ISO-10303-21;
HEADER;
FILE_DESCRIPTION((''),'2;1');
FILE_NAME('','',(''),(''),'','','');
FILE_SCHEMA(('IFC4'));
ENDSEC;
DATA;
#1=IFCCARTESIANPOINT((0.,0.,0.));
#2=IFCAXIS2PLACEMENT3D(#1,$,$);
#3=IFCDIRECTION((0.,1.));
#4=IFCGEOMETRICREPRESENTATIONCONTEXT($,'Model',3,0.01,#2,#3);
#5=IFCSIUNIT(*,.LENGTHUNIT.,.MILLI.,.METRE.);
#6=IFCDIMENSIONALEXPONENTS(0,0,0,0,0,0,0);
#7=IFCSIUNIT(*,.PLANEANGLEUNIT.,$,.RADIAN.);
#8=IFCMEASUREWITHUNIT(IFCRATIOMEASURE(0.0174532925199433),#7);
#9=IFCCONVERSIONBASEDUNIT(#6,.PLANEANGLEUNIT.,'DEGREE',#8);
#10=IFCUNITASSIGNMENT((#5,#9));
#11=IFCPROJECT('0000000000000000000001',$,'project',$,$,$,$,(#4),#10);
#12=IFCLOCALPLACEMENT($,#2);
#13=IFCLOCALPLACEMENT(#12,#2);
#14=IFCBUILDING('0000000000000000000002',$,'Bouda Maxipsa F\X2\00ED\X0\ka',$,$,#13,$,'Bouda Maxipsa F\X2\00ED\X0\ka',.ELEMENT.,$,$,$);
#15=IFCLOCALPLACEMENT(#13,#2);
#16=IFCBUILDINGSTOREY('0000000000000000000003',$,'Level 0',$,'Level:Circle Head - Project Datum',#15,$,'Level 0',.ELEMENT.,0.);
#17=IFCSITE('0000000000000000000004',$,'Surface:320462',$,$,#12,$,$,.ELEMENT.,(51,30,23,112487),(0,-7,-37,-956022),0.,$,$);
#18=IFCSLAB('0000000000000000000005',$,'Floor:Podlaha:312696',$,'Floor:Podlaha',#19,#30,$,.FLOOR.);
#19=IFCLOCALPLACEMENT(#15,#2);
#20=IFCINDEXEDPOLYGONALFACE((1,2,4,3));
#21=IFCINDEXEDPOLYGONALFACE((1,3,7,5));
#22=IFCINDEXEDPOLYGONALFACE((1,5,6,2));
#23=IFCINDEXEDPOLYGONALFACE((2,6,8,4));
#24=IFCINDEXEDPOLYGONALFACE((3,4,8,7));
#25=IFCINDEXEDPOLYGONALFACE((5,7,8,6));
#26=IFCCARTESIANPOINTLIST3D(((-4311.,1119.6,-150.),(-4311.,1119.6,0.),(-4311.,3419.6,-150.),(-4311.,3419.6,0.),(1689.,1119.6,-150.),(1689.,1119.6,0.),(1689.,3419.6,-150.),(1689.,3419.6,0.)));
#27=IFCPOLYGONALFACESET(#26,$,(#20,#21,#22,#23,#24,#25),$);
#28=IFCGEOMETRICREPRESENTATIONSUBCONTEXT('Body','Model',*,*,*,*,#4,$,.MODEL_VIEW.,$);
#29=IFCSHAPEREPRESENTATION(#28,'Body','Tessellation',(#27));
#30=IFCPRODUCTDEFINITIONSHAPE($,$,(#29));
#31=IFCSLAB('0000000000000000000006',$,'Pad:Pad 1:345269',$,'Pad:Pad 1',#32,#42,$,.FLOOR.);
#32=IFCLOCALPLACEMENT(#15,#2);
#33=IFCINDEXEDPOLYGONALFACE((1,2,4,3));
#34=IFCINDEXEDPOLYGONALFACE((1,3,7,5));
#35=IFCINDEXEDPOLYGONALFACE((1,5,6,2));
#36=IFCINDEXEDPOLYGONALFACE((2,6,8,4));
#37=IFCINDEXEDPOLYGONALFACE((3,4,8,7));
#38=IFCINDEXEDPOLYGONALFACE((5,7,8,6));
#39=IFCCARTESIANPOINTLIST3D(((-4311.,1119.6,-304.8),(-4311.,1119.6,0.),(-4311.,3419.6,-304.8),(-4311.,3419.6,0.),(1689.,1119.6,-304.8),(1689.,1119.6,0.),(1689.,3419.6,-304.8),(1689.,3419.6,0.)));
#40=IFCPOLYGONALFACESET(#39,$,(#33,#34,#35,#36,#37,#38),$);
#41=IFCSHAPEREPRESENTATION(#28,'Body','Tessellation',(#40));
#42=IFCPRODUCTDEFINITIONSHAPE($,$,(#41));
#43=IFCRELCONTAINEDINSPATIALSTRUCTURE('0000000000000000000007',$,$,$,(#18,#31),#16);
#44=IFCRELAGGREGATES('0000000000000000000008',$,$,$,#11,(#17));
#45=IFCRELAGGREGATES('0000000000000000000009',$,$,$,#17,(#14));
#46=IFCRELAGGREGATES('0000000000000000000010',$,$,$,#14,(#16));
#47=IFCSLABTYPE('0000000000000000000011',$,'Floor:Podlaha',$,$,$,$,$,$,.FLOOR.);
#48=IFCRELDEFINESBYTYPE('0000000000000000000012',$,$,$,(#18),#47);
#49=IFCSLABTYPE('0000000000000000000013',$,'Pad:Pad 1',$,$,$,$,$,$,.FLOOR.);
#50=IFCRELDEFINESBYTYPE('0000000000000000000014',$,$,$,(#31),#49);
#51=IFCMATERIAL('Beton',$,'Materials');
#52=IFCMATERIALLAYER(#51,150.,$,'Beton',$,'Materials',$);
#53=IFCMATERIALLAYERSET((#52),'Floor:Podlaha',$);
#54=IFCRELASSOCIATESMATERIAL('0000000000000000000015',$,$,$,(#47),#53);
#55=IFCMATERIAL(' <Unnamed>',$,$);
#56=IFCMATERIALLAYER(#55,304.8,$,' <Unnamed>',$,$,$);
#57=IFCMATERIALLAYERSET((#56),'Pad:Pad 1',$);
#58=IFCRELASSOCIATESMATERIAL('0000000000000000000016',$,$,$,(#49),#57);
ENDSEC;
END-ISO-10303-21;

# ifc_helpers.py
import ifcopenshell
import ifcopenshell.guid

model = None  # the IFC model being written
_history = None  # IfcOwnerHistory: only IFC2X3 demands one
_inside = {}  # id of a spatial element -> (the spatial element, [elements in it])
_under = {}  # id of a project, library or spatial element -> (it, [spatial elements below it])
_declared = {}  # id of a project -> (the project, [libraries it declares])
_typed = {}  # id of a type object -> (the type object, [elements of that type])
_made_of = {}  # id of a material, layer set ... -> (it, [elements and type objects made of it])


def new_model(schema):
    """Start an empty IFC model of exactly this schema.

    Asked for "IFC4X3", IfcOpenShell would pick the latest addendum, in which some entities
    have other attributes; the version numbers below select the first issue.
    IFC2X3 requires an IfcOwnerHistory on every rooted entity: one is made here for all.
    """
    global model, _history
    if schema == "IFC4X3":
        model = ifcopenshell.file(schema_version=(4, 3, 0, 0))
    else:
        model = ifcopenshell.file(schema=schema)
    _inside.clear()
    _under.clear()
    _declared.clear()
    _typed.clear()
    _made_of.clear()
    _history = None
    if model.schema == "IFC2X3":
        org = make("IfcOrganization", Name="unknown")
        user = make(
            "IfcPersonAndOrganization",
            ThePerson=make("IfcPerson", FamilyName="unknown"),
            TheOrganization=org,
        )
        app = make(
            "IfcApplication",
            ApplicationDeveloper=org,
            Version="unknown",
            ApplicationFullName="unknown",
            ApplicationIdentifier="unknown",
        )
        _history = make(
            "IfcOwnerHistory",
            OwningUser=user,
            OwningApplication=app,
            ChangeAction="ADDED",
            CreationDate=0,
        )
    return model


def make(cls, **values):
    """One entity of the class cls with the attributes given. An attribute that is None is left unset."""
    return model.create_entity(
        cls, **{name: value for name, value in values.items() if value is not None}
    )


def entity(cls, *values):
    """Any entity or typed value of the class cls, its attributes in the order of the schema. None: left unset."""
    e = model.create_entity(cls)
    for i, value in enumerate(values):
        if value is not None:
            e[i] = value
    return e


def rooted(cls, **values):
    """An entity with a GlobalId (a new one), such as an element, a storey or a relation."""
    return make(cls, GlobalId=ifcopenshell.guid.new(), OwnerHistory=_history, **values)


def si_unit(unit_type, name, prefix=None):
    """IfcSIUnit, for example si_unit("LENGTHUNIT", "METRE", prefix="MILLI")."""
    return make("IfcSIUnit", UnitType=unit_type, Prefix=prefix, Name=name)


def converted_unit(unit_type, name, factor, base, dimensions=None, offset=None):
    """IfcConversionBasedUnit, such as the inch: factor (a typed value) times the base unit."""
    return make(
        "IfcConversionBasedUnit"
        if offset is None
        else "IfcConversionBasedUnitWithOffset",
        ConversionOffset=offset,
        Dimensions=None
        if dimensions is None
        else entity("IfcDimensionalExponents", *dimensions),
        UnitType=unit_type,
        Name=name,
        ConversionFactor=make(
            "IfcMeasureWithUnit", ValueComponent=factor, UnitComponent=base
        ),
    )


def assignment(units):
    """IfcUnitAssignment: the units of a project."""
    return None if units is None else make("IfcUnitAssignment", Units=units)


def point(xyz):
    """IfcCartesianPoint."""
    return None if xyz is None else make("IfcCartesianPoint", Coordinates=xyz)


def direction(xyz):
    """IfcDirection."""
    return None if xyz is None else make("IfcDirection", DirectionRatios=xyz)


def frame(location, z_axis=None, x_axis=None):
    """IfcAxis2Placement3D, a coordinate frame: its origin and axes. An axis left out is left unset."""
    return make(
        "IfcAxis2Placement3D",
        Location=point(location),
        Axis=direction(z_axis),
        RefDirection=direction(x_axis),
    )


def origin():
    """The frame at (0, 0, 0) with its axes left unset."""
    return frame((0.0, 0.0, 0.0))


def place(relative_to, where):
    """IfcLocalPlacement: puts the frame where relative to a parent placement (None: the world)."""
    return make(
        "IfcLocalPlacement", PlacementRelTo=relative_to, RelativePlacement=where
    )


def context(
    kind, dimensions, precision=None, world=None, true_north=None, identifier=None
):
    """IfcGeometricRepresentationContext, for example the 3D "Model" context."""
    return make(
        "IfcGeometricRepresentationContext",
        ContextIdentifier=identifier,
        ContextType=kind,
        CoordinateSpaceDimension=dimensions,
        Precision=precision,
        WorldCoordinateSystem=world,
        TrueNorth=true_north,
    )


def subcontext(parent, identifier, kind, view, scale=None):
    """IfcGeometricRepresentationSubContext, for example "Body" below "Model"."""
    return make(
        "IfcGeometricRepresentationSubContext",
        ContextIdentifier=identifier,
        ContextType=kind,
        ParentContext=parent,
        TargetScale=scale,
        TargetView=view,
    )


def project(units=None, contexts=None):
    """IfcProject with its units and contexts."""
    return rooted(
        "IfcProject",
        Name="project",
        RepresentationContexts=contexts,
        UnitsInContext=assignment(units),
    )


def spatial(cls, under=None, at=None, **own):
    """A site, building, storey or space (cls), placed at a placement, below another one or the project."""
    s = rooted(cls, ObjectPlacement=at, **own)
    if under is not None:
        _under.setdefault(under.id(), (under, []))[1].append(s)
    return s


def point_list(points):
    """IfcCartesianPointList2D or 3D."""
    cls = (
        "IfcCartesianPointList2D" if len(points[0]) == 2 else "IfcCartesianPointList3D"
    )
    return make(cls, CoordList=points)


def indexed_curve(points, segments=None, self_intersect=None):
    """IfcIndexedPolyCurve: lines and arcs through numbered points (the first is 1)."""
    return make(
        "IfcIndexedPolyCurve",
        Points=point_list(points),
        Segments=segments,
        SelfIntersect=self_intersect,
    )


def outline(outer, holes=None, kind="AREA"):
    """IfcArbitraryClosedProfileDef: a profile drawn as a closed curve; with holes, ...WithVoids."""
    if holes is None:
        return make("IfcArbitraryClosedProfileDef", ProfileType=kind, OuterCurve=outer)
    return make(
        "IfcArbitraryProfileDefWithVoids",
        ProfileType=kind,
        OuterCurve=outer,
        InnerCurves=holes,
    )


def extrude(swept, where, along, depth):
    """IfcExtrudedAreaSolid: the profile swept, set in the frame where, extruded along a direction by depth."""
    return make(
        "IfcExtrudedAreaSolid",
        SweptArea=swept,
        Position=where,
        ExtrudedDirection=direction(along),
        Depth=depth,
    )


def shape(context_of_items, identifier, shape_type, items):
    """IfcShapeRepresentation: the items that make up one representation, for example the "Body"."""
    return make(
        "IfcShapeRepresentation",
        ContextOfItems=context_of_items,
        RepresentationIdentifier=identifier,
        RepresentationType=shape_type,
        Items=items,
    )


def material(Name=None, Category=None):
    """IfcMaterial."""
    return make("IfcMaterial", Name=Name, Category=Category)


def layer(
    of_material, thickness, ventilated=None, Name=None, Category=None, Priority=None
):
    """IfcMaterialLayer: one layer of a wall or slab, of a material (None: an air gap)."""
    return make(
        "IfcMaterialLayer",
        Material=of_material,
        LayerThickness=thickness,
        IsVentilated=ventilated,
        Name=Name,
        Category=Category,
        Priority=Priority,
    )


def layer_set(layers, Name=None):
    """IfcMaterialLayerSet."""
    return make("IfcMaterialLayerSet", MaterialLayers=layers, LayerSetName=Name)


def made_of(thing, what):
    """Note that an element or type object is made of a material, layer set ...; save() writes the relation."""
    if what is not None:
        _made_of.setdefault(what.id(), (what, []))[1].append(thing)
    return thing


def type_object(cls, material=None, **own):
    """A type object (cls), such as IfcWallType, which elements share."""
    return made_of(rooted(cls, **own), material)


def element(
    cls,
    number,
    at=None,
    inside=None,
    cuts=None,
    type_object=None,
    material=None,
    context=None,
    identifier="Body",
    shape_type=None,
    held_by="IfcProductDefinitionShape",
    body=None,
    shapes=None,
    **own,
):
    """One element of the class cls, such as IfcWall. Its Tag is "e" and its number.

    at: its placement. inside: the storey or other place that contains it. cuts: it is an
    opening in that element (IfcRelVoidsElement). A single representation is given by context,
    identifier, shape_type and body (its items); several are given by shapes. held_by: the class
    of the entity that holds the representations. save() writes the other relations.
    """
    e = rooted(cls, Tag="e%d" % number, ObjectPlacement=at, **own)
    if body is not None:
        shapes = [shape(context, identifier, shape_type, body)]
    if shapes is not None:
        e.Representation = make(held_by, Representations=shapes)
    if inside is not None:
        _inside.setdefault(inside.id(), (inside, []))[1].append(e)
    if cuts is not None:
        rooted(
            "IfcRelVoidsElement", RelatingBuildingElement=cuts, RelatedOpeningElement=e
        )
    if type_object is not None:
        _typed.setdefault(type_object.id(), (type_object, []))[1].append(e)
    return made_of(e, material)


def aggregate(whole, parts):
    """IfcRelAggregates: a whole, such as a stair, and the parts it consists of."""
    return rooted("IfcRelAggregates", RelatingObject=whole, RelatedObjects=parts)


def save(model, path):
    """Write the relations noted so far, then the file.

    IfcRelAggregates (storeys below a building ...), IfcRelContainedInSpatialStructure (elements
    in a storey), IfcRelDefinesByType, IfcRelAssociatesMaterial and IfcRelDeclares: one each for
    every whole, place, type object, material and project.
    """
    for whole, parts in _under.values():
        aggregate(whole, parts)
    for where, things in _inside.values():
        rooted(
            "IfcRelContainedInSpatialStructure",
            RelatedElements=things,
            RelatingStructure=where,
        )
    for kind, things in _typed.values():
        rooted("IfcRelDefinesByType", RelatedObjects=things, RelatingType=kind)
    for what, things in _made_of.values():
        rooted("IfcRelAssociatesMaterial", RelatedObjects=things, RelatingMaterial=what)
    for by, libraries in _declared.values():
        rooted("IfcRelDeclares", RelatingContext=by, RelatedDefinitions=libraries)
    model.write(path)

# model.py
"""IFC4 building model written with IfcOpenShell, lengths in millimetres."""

from ifc_helpers import new_model, entity, si_unit, converted_unit, direction, frame, origin, place, context, subcontext, project, spatial, indexed_curve, outline, extrude, material, layer, layer_set, type_object, element, save


model = new_model("IFC4")

# Units and contexts
model_context = context("Model", 3, precision=0.01, world=origin(), true_north=direction((0.0, 1.0)))
body_context = subcontext(model_context, "Body", "Model", "MODEL_VIEW")
ifc_project = project(units=[si_unit("LENGTHUNIT", "METRE", prefix="MILLI"), converted_unit("PLANEANGLEUNIT", "DEGREE", entity("IfcRatioMeasure", 0.0174532925199433), si_unit("PLANEANGLEUNIT", "RADIAN"), dimensions=[0, 0, 0, 0, 0, 0, 0])], contexts=[model_context])

# Site, building, storey
site_placement = place(None, origin())
site = spatial("IfcSite", under=ifc_project, at=site_placement, Name="Surface:320462", CompositionType="ELEMENT", RefLatitude=(51, 30, 23, 112487), RefLongitude=(0, -7, -37, -956022), RefElevation=0.0)
building_placement = place(site_placement, origin())
building = spatial("IfcBuilding", under=site, at=building_placement, Name="Bouda Maxipsa Fíka", LongName="Bouda Maxipsa Fíka", CompositionType="ELEMENT")
storey_placement = place(building_placement, origin())
storey = spatial("IfcBuildingStorey", under=building, at=storey_placement, Name="Level 0", ObjectType="Level:Circle Head - Project Datum", LongName="Level 0", CompositionType="ELEMENT", Elevation=0.0)

# Slabs
ifc_material_1 = material(Name="Beton", Category="Materials")
ifc_layer_1 = layer(ifc_material_1, 150.0, Name="Beton", Category="Materials")
ifc_layer_set_1 = layer_set([ifc_layer_1], Name="Floor:Podlaha")
slab_type_1 = type_object("IfcSlabType", Name="Floor:Podlaha", PredefinedType="FLOOR", material=ifc_layer_set_1)
slab_1_placement = place(storey_placement, origin())
element("IfcSlab", 1, at=slab_1_placement, inside=storey, type_object=slab_type_1, Name="Floor:Podlaha:312696", ObjectType="Floor:Podlaha", PredefinedType="FLOOR", context=body_context, shape_type="SweptSolid", body=[
    extrude(outline(indexed_curve([(-1150.0, -3000.0), (1150.0, -3000.0), (1150.0, 3000.0), (-1150.0, 3000.0), (-1150.0, -3000.0)], self_intersect=False)), frame((-1311.0, 2269.6, 0.0), z_axis=(0.0, 0.0, -1.0), x_axis=(0.0, 1.0, 0.0)), (0.0, 0.0, 1.0), 150.0),
])
ifc_material_2 = material(Name=" <Unnamed>")
ifc_layer_2 = layer(ifc_material_2, 304.8, Name=" <Unnamed>")
ifc_layer_set_2 = layer_set([ifc_layer_2], Name="Pad:Pad 1")
slab_type_2 = type_object("IfcSlabType", Name="Pad:Pad 1", PredefinedType="FLOOR", material=ifc_layer_set_2)
slab_2_placement = place(storey_placement, origin())
element("IfcSlab", 2, at=slab_2_placement, inside=storey, type_object=slab_type_2, Name="Pad:Pad 1:345269", ObjectType="Pad:Pad 1", PredefinedType="FLOOR", context=body_context, shape_type="SweptSolid", body=[
    extrude(outline(indexed_curve([(-1150.0, -3000.0), (1150.0, -3000.0), (1150.0, 3000.0), (-1150.0, 3000.0), (-1150.0, -3000.0)], self_intersect=False)), frame((-1311.0, 2269.6, -304.8), z_axis=(0.0, 0.0, 1.0), x_axis=(0.0, -1.0, 0.0)), (0.0, 0.0, 1.0), 304.8),
])

save(model, "model.ifc")
